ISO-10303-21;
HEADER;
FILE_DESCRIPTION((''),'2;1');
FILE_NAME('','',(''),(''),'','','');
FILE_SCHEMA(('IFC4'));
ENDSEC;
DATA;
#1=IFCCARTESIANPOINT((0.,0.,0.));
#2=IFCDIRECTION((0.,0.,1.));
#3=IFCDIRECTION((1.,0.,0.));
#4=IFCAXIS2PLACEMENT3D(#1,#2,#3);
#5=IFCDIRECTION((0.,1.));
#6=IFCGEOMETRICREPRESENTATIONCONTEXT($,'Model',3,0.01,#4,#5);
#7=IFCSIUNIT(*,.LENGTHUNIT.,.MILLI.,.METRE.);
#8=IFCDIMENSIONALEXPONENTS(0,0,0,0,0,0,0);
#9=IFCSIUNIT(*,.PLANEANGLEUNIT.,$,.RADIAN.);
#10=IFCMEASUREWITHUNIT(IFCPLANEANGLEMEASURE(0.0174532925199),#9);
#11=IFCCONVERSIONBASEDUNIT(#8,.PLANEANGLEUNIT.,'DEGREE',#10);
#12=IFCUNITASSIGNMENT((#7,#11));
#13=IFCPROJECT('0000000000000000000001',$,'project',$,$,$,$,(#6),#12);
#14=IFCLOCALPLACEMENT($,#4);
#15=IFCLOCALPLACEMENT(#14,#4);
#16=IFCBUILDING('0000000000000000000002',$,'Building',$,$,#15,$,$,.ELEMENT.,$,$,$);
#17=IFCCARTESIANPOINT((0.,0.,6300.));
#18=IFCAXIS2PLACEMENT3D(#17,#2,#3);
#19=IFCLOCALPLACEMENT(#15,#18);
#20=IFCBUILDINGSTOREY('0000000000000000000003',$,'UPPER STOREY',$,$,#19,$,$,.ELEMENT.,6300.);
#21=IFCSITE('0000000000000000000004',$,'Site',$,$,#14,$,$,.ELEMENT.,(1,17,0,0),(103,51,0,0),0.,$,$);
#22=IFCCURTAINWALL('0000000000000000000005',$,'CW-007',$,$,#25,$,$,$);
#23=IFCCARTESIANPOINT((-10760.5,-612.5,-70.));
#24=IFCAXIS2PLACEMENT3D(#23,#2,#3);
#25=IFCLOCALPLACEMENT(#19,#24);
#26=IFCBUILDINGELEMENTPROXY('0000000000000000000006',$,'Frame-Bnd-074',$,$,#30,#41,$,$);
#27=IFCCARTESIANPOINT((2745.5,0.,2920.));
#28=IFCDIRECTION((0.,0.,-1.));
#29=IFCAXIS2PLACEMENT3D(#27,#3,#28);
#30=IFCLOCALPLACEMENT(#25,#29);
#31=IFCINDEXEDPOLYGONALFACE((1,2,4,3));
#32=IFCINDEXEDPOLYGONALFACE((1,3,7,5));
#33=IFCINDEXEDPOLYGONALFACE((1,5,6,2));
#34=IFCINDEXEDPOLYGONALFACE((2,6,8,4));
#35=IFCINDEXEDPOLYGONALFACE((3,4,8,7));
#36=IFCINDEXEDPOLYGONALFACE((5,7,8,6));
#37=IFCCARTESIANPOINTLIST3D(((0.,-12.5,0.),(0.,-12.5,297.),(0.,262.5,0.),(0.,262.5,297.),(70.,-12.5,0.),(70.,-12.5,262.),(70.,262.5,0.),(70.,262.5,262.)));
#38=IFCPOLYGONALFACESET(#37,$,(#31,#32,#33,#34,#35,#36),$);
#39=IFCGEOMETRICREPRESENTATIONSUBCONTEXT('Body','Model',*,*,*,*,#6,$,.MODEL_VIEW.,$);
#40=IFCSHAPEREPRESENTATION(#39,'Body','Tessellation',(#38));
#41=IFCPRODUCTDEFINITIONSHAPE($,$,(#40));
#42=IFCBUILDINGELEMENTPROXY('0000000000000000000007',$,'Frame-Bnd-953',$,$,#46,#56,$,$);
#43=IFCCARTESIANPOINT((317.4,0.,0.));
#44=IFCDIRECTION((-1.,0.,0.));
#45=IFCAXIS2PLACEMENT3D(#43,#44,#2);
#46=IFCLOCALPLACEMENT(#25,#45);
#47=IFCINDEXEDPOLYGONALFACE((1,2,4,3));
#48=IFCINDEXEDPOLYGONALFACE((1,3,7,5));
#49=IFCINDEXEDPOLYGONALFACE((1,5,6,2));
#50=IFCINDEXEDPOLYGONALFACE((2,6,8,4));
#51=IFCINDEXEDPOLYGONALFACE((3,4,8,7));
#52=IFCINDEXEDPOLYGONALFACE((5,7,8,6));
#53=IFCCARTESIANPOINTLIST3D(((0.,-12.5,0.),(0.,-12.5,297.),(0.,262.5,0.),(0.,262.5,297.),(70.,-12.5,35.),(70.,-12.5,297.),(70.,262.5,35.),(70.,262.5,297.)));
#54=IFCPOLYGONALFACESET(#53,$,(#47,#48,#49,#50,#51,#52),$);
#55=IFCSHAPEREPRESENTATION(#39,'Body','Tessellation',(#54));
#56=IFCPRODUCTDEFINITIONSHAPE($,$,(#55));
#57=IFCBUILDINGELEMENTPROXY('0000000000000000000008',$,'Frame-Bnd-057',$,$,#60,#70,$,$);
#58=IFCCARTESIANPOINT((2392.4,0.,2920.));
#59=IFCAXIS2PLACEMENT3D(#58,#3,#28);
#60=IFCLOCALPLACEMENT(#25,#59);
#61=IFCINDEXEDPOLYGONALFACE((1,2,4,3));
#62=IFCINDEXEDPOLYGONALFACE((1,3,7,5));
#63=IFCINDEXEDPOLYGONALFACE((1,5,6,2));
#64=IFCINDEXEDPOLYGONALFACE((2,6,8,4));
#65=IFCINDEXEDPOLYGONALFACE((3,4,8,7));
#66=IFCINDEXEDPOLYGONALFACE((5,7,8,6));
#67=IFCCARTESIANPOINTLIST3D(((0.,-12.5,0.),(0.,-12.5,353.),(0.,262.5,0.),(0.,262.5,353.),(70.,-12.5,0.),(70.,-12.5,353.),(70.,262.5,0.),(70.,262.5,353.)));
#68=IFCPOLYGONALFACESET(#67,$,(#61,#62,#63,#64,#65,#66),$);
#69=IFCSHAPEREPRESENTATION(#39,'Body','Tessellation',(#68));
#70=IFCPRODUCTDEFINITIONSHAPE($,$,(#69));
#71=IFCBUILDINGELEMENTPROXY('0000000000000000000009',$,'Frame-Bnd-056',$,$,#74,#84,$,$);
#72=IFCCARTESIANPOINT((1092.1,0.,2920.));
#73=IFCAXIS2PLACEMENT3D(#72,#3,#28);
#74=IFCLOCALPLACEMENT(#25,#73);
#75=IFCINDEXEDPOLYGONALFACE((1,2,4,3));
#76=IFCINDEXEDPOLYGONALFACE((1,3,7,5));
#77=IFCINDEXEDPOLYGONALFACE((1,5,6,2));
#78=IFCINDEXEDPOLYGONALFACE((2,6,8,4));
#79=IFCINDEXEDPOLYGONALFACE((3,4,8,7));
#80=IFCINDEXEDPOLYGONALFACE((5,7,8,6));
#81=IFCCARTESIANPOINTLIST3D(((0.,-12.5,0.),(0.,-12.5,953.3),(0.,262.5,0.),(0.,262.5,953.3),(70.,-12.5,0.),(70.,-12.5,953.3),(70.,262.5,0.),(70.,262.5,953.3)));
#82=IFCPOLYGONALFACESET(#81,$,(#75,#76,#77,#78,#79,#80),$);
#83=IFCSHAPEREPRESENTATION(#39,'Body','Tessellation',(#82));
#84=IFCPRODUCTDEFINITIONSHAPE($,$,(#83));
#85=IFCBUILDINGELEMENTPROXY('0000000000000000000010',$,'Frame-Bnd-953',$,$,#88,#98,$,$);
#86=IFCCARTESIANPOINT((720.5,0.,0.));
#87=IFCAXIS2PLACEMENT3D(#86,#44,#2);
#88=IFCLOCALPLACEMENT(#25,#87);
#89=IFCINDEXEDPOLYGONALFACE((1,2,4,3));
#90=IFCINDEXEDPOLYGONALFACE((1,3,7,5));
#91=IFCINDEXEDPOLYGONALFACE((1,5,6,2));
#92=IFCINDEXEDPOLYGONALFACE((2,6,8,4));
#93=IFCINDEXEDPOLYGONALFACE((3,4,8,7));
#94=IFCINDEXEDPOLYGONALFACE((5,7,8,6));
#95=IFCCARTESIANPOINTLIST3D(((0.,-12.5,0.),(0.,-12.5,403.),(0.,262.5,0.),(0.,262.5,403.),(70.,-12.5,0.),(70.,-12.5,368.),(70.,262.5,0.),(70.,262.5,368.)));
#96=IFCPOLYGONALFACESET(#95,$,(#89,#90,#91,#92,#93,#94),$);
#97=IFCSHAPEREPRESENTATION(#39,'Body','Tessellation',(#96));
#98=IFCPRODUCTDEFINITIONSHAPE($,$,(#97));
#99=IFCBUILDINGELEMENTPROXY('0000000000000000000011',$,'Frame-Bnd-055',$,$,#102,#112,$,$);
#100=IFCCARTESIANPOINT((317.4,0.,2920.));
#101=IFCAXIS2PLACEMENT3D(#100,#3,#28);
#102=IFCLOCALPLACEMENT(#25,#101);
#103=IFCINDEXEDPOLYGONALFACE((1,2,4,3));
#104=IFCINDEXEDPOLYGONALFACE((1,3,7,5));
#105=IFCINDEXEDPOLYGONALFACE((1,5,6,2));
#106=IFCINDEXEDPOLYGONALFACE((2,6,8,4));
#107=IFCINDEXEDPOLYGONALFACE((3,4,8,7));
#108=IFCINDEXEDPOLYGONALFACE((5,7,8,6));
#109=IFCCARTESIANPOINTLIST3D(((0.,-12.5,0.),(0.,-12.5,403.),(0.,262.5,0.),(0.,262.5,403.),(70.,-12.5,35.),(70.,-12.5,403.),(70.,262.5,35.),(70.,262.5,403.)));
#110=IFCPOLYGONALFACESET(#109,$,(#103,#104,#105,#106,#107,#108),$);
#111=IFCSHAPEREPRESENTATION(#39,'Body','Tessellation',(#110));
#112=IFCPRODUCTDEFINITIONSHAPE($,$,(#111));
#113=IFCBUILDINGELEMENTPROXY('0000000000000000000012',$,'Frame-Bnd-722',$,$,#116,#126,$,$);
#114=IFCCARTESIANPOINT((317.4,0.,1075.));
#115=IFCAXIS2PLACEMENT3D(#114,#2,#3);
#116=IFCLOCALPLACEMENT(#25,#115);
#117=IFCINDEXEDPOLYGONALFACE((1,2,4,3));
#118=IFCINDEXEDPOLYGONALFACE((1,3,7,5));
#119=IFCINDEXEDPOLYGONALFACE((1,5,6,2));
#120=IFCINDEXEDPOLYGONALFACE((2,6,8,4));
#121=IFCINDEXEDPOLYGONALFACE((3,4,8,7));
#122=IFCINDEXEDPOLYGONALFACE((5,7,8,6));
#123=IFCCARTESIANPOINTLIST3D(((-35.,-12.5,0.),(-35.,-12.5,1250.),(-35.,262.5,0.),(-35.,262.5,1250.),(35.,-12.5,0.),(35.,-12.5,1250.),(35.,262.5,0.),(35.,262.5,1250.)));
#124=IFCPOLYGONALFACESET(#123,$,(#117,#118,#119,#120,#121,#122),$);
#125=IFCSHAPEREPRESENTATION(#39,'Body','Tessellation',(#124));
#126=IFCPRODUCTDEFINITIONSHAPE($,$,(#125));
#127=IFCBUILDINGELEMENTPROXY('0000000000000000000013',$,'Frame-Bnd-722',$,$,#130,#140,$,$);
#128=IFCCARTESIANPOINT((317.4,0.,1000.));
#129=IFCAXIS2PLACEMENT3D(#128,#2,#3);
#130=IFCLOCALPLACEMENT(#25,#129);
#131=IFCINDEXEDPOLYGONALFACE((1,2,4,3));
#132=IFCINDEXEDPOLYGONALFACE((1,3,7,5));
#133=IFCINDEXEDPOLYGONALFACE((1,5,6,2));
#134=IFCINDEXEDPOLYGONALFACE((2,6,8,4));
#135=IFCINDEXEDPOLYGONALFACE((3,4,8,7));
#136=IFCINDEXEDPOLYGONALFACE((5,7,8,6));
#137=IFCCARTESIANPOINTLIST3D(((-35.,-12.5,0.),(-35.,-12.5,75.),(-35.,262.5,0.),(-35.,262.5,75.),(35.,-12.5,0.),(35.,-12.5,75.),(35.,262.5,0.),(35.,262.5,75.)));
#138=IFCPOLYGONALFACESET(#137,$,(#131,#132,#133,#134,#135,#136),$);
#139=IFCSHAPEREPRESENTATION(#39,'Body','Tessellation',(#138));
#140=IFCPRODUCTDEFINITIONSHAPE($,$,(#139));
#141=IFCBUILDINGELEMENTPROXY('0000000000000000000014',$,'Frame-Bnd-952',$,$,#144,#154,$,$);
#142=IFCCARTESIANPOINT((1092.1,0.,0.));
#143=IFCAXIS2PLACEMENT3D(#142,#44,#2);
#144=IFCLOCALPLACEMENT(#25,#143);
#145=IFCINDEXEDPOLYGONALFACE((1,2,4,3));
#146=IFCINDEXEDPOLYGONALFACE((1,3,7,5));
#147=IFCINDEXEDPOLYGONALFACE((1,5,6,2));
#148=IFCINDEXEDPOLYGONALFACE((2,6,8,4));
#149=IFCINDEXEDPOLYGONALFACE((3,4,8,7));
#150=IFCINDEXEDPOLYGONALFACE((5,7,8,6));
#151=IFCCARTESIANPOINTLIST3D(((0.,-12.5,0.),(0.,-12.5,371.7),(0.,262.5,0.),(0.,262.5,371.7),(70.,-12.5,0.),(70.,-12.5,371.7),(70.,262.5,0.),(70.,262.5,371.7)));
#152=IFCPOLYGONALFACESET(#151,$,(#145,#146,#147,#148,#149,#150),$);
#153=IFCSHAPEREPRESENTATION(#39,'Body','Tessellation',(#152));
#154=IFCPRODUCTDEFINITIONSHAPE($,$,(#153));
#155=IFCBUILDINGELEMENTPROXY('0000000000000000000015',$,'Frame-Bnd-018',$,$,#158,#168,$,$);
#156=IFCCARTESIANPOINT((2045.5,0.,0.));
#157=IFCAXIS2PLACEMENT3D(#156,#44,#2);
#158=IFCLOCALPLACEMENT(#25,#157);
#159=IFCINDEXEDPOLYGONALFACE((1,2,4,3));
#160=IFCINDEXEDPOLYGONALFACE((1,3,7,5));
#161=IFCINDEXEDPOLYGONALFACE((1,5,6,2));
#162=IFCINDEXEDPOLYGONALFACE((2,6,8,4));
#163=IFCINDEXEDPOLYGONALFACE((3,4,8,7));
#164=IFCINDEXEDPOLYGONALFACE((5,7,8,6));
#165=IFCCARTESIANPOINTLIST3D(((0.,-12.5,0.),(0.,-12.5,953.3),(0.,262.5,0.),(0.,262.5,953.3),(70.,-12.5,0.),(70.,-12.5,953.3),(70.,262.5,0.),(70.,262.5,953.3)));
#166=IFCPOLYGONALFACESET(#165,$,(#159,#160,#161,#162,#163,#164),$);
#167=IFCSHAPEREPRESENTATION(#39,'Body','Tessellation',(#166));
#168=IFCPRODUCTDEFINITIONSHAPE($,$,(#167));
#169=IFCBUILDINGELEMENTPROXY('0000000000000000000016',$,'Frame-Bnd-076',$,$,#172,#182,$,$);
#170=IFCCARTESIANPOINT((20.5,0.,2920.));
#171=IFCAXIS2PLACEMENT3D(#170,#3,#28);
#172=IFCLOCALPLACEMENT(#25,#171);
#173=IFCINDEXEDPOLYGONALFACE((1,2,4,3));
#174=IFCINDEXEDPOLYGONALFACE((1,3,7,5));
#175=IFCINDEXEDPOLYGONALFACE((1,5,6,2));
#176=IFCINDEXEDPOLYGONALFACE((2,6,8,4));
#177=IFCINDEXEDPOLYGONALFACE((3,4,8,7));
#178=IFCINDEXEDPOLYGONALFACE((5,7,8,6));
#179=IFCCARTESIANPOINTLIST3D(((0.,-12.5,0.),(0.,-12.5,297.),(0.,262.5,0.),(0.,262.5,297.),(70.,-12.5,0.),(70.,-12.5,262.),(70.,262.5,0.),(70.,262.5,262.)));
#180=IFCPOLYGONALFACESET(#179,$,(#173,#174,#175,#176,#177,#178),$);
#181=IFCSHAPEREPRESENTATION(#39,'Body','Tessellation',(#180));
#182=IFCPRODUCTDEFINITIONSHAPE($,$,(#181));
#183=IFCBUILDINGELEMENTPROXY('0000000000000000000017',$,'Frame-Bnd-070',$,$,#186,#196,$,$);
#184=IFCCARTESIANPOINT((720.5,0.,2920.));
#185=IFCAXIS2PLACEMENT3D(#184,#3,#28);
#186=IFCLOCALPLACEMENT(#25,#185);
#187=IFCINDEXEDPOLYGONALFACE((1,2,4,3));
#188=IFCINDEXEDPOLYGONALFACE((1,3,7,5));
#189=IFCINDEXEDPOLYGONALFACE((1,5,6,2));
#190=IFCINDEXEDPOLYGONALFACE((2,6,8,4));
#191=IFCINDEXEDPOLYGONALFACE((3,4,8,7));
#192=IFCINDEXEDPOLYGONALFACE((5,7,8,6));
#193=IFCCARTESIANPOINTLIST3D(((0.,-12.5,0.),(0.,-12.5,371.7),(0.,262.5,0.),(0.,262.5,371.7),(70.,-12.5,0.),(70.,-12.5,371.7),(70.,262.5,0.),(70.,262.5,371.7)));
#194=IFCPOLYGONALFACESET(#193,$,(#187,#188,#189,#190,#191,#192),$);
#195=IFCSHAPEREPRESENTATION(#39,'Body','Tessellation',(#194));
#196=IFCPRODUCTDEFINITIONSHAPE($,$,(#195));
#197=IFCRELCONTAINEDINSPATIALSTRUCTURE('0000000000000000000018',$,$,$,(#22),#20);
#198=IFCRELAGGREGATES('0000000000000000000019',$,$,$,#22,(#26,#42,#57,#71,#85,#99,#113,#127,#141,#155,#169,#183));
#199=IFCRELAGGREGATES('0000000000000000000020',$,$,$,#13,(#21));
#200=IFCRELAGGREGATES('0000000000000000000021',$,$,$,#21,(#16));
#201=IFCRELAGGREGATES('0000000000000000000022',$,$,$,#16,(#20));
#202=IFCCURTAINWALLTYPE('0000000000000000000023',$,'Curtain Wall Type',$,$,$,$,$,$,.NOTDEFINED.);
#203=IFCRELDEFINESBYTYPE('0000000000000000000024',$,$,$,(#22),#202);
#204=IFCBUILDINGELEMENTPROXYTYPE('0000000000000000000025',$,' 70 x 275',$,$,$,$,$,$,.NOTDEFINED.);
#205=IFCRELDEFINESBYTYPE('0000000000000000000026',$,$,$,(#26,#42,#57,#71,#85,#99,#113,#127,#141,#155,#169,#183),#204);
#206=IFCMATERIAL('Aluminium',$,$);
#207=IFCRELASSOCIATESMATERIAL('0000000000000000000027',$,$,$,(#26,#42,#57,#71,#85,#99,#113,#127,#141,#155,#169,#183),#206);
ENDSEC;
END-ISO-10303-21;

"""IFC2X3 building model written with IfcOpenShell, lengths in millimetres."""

from ifc_helpers import new_model, entity, si_unit, converted_unit, direction, frame, origin_with_axes, place, context, subcontext, project, spatial, polyline, outline, extrude, clip, halfspace, material, type_object, element, aggregate, save


model = new_model("IFC2X3")

# Units and contexts
model_context = context("Model", 3, precision=0.01, world=origin_with_axes(), true_north=direction((0.0, 1.0)))
body_context = subcontext(model_context, "Body", "Model", "MODEL_VIEW")
ifc_project = project(units=[si_unit("LENGTHUNIT", "METRE", prefix="MILLI"), converted_unit("PLANEANGLEUNIT", "DEGREE", entity("IfcPlaneAngleMeasure", 0.0174532925199), si_unit("PLANEANGLEUNIT", "RADIAN"), dimensions=[0, 0, 0, 0, 0, 0, 0])], contexts=[model_context])

# Site, building, storey
site_placement = place(None, origin_with_axes())
site = spatial("IfcSite", under=ifc_project, at=site_placement, Name="Site", CompositionType="ELEMENT", RefLatitude=(1, 17, 0, 0), RefLongitude=(103, 51, 0, 0), RefElevation=0.0)
building_placement = place(site_placement, origin_with_axes())
building = spatial("IfcBuilding", under=site, at=building_placement, Name="Building", CompositionType="ELEMENT")
storey_placement = place(building_placement, frame((0.0, 0.0, 6300.0), z_axis=(0.0, 0.0, 1.0), x_axis=(1.0, 0.0, 0.0)))
storey = spatial("IfcBuildingStorey", under=building, at=storey_placement, Name="UPPER STOREY", CompositionType="ELEMENT", Elevation=6300.0)

# Curtain wall, building element proxies
curtain_wall_type = type_object("IfcCurtainWallType", Name="Curtain Wall Type", PredefinedType="NOTDEFINED")
curtain_wall_placement = place(storey_placement, frame((-10760.5, -612.5, -70.0), z_axis=(0.0, 0.0, 1.0), x_axis=(1.0, 0.0, 0.0)))
curtain_wall = element("IfcCurtainWall", 1, at=curtain_wall_placement, inside=storey, type_object=curtain_wall_type, Name="CW-007")
ifc_material_1 = material(Name="Aluminium")
building_element_proxy_type_1 = type_object("IfcBuildingElementProxyType", Name=" 70 x 275", PredefinedType="NOTDEFINED")
proxy_1_placement = place(curtain_wall_placement, frame((2745.5, 0.0, 2920.0), z_axis=(1.0, 0.0, 0.0), x_axis=(0.0, 0.0, -1.0)))
proxy_1 = element("IfcBuildingElementProxy", 2, at=proxy_1_placement, type_object=building_element_proxy_type_1, material=ifc_material_1, Name="Frame-Bnd-074", context=body_context, shape_type="Clipping", body=[
    clip(extrude(outline(polyline([(-262.5, 70.0), (-262.5, 0.0), (12.5, 0.0), (12.5, 70.0), (-262.5, 70.0)])), frame((0.0, 0.0, 0.0), z_axis=(0.0, 0.0, 1.0), x_axis=(0.0, -1.0, 0.0)), (0.0, 0.0, 1.0), 297.0), halfspace(frame((118.8, 0.0, 237.6), z_axis=(-0.447214, 0.0, -0.894427), x_axis=(0.0, 1.0, 0.0)), True)),
])
proxy_2_placement = place(curtain_wall_placement, frame((317.4, 0.0, 0.0), z_axis=(-1.0, 0.0, 0.0), x_axis=(0.0, 0.0, 1.0)))
proxy_2 = element("IfcBuildingElementProxy", 3, at=proxy_2_placement, type_object=building_element_proxy_type_1, material=ifc_material_1, Name="Frame-Bnd-953", context=body_context, shape_type="Clipping", body=[
    clip(extrude(outline(polyline([(262.5, -70.0), (262.5, 0.0), (-12.5, 0.0), (-12.5, -70.0), (262.5, -70.0)])), frame((0.0, 0.0, 0.0), z_axis=(0.0, 0.0, 1.0), x_axis=(0.0, 1.0, 0.0)), (0.0, 0.0, 1.0), 297.0), halfspace(frame((0.0, 0.0, 0.0), z_axis=(-0.447214, 0.0, 0.894427), x_axis=(0.0, -1.0, 0.0)), True)),
])
proxy_3_placement = place(curtain_wall_placement, frame((2392.4, 0.0, 2920.0), z_axis=(1.0, 0.0, 0.0), x_axis=(0.0, 0.0, -1.0)))
proxy_3 = element("IfcBuildingElementProxy", 4, at=proxy_3_placement, type_object=building_element_proxy_type_1, material=ifc_material_1, Name="Frame-Bnd-057", context=body_context, shape_type="SweptSolid", body=[
    extrude(outline(polyline([(-262.5, 70.0), (-262.5, 0.0), (12.5, 0.0), (12.5, 70.0), (-262.5, 70.0)])), frame((0.0, 0.0, 0.0), z_axis=(0.0, 0.0, 1.0), x_axis=(0.0, -1.0, 0.0)), (0.0, 0.0, 1.0), 353.0),
])
proxy_4_placement = place(curtain_wall_placement, frame((1092.1, 0.0, 2920.0), z_axis=(1.0, 0.0, 0.0), x_axis=(0.0, 0.0, -1.0)))
proxy_4 = element("IfcBuildingElementProxy", 5, at=proxy_4_placement, type_object=building_element_proxy_type_1, material=ifc_material_1, Name="Frame-Bnd-056", context=body_context, shape_type="SweptSolid", body=[
    extrude(outline(polyline([(-262.5, 70.0), (-262.5, 0.0), (12.5, 0.0), (12.5, 70.0), (-262.5, 70.0)])), frame((0.0, 0.0, 0.0), z_axis=(0.0, 0.0, 1.0), x_axis=(0.0, -1.0, 0.0)), (0.0, 0.0, 1.0), 953.3),
])
proxy_5_placement = place(curtain_wall_placement, frame((720.5, 0.0, 0.0), z_axis=(-1.0, 0.0, 0.0), x_axis=(0.0, 0.0, 1.0)))
proxy_5 = element("IfcBuildingElementProxy", 6, at=proxy_5_placement, type_object=building_element_proxy_type_1, material=ifc_material_1, Name="Frame-Bnd-953", context=body_context, shape_type="Clipping", body=[
    clip(extrude(outline(polyline([(262.5, -70.0), (262.5, 0.0), (-12.5, 0.0), (-12.5, -70.0), (262.5, -70.0)])), frame((0.0, 0.0, 0.0), z_axis=(0.0, 0.0, 1.0), x_axis=(0.0, 1.0, 0.0)), (0.0, 0.0, 1.0), 403.0), halfspace(frame((161.2, 0.0, 322.4), z_axis=(-0.447214, 0.0, -0.894427), x_axis=(0.0, 1.0, 0.0)), True)),
])
proxy_6_placement = place(curtain_wall_placement, frame((317.4, 0.0, 2920.0), z_axis=(1.0, 0.0, 0.0), x_axis=(0.0, 0.0, -1.0)))
proxy_6 = element("IfcBuildingElementProxy", 7, at=proxy_6_placement, type_object=building_element_proxy_type_1, material=ifc_material_1, Name="Frame-Bnd-055", context=body_context, shape_type="Clipping", body=[
    clip(extrude(outline(polyline([(-262.5, 70.0), (-262.5, 0.0), (12.5, 0.0), (12.5, 70.0), (-262.5, 70.0)])), frame((0.0, 0.0, 0.0), z_axis=(0.0, 0.0, 1.0), x_axis=(0.0, -1.0, 0.0)), (0.0, 0.0, 1.0), 403.0), halfspace(frame((0.0, 0.0, 0.0), z_axis=(-0.447214, 0.0, 0.894427), x_axis=(0.0, -1.0, 0.0)), True)),
])
proxy_7_placement = place(curtain_wall_placement, frame((317.4, 0.0, 1075.0), z_axis=(0.0, 0.0, 1.0), x_axis=(1.0, 0.0, 0.0)))
proxy_7 = element("IfcBuildingElementProxy", 8, at=proxy_7_placement, type_object=building_element_proxy_type_1, material=ifc_material_1, Name="Frame-Bnd-722", context=body_context, shape_type="SweptSolid", body=[
    extrude(outline(polyline([(35.0, 262.5), (-35.0, 262.5), (-35.0, -12.5), (35.0, -12.5), (35.0, 262.5)])), frame((0.0, 0.0, 0.0), z_axis=(0.0, 0.0, 1.0), x_axis=(1.0, 0.0, 0.0)), (0.0, 0.0, 1.0), 1250.0),
])
proxy_8_placement = place(curtain_wall_placement, frame((317.4, 0.0, 1000.0), z_axis=(0.0, 0.0, 1.0), x_axis=(1.0, 0.0, 0.0)))
proxy_8 = element("IfcBuildingElementProxy", 9, at=proxy_8_placement, type_object=building_element_proxy_type_1, material=ifc_material_1, Name="Frame-Bnd-722", context=body_context, shape_type="SweptSolid", body=[
    extrude(outline(polyline([(35.0, 262.5), (-35.0, 262.5), (-35.0, -12.5), (35.0, -12.5), (35.0, 262.5)])), frame((0.0, 0.0, 0.0), z_axis=(0.0, 0.0, 1.0), x_axis=(1.0, 0.0, 0.0)), (0.0, 0.0, 1.0), 75.0),
])
proxy_9_placement = place(curtain_wall_placement, frame((1092.1, 0.0, 0.0), z_axis=(-1.0, 0.0, 0.0), x_axis=(0.0, 0.0, 1.0)))
proxy_9 = element("IfcBuildingElementProxy", 10, at=proxy_9_placement, type_object=building_element_proxy_type_1, material=ifc_material_1, Name="Frame-Bnd-952", context=body_context, shape_type="SweptSolid", body=[
    extrude(outline(polyline([(262.5, -70.0), (262.5, 0.0), (-12.5, 0.0), (-12.5, -70.0), (262.5, -70.0)])), frame((0.0, 0.0, 0.0), z_axis=(0.0, 0.0, 1.0), x_axis=(0.0, 1.0, 0.0)), (0.0, 0.0, 1.0), 371.7),
])
proxy_10_placement = place(curtain_wall_placement, frame((2045.5, 0.0, 0.0), z_axis=(-1.0, 0.0, 0.0), x_axis=(0.0, 0.0, 1.0)))
proxy_10 = element("IfcBuildingElementProxy", 11, at=proxy_10_placement, type_object=building_element_proxy_type_1, material=ifc_material_1, Name="Frame-Bnd-018", context=body_context, shape_type="SweptSolid", body=[
    extrude(outline(polyline([(262.5, -70.0), (262.5, 0.0), (-12.5, 0.0), (-12.5, -70.0), (262.5, -70.0)])), frame((0.0, 0.0, 0.0), z_axis=(0.0, 0.0, 1.0), x_axis=(0.0, 1.0, 0.0)), (0.0, 0.0, 1.0), 953.3),
])
proxy_11_placement = place(curtain_wall_placement, frame((20.5, 0.0, 2920.0), z_axis=(1.0, 0.0, 0.0), x_axis=(0.0, 0.0, -1.0)))
proxy_11 = element("IfcBuildingElementProxy", 12, at=proxy_11_placement, type_object=building_element_proxy_type_1, material=ifc_material_1, Name="Frame-Bnd-076", context=body_context, shape_type="Clipping", body=[
    clip(extrude(outline(polyline([(-262.5, 70.0), (-262.5, 0.0), (12.5, 0.0), (12.5, 70.0), (-262.5, 70.0)])), frame((0.0, 0.0, 0.0), z_axis=(0.0, 0.0, 1.0), x_axis=(0.0, -1.0, 0.0)), (0.0, 0.0, 1.0), 297.0), halfspace(frame((118.8, 0.0, 237.6), z_axis=(-0.447214, 0.0, -0.894427), x_axis=(0.0, 1.0, 0.0)), True)),
])
proxy_12_placement = place(curtain_wall_placement, frame((720.5, 0.0, 2920.0), z_axis=(1.0, 0.0, 0.0), x_axis=(0.0, 0.0, -1.0)))
proxy_12 = element("IfcBuildingElementProxy", 13, at=proxy_12_placement, type_object=building_element_proxy_type_1, material=ifc_material_1, Name="Frame-Bnd-070", context=body_context, shape_type="SweptSolid", body=[
    extrude(outline(polyline([(-262.5, 70.0), (-262.5, 0.0), (12.5, 0.0), (12.5, 70.0), (-262.5, 70.0)])), frame((0.0, 0.0, 0.0), z_axis=(0.0, 0.0, 1.0), x_axis=(0.0, -1.0, 0.0)), (0.0, 0.0, 1.0), 371.7),
])
aggregate(curtain_wall, [proxy_1, proxy_2, proxy_3, proxy_4, proxy_5, proxy_6, proxy_7, proxy_8, proxy_9, proxy_10, proxy_11, proxy_12])

save(model, "model.ifc")
